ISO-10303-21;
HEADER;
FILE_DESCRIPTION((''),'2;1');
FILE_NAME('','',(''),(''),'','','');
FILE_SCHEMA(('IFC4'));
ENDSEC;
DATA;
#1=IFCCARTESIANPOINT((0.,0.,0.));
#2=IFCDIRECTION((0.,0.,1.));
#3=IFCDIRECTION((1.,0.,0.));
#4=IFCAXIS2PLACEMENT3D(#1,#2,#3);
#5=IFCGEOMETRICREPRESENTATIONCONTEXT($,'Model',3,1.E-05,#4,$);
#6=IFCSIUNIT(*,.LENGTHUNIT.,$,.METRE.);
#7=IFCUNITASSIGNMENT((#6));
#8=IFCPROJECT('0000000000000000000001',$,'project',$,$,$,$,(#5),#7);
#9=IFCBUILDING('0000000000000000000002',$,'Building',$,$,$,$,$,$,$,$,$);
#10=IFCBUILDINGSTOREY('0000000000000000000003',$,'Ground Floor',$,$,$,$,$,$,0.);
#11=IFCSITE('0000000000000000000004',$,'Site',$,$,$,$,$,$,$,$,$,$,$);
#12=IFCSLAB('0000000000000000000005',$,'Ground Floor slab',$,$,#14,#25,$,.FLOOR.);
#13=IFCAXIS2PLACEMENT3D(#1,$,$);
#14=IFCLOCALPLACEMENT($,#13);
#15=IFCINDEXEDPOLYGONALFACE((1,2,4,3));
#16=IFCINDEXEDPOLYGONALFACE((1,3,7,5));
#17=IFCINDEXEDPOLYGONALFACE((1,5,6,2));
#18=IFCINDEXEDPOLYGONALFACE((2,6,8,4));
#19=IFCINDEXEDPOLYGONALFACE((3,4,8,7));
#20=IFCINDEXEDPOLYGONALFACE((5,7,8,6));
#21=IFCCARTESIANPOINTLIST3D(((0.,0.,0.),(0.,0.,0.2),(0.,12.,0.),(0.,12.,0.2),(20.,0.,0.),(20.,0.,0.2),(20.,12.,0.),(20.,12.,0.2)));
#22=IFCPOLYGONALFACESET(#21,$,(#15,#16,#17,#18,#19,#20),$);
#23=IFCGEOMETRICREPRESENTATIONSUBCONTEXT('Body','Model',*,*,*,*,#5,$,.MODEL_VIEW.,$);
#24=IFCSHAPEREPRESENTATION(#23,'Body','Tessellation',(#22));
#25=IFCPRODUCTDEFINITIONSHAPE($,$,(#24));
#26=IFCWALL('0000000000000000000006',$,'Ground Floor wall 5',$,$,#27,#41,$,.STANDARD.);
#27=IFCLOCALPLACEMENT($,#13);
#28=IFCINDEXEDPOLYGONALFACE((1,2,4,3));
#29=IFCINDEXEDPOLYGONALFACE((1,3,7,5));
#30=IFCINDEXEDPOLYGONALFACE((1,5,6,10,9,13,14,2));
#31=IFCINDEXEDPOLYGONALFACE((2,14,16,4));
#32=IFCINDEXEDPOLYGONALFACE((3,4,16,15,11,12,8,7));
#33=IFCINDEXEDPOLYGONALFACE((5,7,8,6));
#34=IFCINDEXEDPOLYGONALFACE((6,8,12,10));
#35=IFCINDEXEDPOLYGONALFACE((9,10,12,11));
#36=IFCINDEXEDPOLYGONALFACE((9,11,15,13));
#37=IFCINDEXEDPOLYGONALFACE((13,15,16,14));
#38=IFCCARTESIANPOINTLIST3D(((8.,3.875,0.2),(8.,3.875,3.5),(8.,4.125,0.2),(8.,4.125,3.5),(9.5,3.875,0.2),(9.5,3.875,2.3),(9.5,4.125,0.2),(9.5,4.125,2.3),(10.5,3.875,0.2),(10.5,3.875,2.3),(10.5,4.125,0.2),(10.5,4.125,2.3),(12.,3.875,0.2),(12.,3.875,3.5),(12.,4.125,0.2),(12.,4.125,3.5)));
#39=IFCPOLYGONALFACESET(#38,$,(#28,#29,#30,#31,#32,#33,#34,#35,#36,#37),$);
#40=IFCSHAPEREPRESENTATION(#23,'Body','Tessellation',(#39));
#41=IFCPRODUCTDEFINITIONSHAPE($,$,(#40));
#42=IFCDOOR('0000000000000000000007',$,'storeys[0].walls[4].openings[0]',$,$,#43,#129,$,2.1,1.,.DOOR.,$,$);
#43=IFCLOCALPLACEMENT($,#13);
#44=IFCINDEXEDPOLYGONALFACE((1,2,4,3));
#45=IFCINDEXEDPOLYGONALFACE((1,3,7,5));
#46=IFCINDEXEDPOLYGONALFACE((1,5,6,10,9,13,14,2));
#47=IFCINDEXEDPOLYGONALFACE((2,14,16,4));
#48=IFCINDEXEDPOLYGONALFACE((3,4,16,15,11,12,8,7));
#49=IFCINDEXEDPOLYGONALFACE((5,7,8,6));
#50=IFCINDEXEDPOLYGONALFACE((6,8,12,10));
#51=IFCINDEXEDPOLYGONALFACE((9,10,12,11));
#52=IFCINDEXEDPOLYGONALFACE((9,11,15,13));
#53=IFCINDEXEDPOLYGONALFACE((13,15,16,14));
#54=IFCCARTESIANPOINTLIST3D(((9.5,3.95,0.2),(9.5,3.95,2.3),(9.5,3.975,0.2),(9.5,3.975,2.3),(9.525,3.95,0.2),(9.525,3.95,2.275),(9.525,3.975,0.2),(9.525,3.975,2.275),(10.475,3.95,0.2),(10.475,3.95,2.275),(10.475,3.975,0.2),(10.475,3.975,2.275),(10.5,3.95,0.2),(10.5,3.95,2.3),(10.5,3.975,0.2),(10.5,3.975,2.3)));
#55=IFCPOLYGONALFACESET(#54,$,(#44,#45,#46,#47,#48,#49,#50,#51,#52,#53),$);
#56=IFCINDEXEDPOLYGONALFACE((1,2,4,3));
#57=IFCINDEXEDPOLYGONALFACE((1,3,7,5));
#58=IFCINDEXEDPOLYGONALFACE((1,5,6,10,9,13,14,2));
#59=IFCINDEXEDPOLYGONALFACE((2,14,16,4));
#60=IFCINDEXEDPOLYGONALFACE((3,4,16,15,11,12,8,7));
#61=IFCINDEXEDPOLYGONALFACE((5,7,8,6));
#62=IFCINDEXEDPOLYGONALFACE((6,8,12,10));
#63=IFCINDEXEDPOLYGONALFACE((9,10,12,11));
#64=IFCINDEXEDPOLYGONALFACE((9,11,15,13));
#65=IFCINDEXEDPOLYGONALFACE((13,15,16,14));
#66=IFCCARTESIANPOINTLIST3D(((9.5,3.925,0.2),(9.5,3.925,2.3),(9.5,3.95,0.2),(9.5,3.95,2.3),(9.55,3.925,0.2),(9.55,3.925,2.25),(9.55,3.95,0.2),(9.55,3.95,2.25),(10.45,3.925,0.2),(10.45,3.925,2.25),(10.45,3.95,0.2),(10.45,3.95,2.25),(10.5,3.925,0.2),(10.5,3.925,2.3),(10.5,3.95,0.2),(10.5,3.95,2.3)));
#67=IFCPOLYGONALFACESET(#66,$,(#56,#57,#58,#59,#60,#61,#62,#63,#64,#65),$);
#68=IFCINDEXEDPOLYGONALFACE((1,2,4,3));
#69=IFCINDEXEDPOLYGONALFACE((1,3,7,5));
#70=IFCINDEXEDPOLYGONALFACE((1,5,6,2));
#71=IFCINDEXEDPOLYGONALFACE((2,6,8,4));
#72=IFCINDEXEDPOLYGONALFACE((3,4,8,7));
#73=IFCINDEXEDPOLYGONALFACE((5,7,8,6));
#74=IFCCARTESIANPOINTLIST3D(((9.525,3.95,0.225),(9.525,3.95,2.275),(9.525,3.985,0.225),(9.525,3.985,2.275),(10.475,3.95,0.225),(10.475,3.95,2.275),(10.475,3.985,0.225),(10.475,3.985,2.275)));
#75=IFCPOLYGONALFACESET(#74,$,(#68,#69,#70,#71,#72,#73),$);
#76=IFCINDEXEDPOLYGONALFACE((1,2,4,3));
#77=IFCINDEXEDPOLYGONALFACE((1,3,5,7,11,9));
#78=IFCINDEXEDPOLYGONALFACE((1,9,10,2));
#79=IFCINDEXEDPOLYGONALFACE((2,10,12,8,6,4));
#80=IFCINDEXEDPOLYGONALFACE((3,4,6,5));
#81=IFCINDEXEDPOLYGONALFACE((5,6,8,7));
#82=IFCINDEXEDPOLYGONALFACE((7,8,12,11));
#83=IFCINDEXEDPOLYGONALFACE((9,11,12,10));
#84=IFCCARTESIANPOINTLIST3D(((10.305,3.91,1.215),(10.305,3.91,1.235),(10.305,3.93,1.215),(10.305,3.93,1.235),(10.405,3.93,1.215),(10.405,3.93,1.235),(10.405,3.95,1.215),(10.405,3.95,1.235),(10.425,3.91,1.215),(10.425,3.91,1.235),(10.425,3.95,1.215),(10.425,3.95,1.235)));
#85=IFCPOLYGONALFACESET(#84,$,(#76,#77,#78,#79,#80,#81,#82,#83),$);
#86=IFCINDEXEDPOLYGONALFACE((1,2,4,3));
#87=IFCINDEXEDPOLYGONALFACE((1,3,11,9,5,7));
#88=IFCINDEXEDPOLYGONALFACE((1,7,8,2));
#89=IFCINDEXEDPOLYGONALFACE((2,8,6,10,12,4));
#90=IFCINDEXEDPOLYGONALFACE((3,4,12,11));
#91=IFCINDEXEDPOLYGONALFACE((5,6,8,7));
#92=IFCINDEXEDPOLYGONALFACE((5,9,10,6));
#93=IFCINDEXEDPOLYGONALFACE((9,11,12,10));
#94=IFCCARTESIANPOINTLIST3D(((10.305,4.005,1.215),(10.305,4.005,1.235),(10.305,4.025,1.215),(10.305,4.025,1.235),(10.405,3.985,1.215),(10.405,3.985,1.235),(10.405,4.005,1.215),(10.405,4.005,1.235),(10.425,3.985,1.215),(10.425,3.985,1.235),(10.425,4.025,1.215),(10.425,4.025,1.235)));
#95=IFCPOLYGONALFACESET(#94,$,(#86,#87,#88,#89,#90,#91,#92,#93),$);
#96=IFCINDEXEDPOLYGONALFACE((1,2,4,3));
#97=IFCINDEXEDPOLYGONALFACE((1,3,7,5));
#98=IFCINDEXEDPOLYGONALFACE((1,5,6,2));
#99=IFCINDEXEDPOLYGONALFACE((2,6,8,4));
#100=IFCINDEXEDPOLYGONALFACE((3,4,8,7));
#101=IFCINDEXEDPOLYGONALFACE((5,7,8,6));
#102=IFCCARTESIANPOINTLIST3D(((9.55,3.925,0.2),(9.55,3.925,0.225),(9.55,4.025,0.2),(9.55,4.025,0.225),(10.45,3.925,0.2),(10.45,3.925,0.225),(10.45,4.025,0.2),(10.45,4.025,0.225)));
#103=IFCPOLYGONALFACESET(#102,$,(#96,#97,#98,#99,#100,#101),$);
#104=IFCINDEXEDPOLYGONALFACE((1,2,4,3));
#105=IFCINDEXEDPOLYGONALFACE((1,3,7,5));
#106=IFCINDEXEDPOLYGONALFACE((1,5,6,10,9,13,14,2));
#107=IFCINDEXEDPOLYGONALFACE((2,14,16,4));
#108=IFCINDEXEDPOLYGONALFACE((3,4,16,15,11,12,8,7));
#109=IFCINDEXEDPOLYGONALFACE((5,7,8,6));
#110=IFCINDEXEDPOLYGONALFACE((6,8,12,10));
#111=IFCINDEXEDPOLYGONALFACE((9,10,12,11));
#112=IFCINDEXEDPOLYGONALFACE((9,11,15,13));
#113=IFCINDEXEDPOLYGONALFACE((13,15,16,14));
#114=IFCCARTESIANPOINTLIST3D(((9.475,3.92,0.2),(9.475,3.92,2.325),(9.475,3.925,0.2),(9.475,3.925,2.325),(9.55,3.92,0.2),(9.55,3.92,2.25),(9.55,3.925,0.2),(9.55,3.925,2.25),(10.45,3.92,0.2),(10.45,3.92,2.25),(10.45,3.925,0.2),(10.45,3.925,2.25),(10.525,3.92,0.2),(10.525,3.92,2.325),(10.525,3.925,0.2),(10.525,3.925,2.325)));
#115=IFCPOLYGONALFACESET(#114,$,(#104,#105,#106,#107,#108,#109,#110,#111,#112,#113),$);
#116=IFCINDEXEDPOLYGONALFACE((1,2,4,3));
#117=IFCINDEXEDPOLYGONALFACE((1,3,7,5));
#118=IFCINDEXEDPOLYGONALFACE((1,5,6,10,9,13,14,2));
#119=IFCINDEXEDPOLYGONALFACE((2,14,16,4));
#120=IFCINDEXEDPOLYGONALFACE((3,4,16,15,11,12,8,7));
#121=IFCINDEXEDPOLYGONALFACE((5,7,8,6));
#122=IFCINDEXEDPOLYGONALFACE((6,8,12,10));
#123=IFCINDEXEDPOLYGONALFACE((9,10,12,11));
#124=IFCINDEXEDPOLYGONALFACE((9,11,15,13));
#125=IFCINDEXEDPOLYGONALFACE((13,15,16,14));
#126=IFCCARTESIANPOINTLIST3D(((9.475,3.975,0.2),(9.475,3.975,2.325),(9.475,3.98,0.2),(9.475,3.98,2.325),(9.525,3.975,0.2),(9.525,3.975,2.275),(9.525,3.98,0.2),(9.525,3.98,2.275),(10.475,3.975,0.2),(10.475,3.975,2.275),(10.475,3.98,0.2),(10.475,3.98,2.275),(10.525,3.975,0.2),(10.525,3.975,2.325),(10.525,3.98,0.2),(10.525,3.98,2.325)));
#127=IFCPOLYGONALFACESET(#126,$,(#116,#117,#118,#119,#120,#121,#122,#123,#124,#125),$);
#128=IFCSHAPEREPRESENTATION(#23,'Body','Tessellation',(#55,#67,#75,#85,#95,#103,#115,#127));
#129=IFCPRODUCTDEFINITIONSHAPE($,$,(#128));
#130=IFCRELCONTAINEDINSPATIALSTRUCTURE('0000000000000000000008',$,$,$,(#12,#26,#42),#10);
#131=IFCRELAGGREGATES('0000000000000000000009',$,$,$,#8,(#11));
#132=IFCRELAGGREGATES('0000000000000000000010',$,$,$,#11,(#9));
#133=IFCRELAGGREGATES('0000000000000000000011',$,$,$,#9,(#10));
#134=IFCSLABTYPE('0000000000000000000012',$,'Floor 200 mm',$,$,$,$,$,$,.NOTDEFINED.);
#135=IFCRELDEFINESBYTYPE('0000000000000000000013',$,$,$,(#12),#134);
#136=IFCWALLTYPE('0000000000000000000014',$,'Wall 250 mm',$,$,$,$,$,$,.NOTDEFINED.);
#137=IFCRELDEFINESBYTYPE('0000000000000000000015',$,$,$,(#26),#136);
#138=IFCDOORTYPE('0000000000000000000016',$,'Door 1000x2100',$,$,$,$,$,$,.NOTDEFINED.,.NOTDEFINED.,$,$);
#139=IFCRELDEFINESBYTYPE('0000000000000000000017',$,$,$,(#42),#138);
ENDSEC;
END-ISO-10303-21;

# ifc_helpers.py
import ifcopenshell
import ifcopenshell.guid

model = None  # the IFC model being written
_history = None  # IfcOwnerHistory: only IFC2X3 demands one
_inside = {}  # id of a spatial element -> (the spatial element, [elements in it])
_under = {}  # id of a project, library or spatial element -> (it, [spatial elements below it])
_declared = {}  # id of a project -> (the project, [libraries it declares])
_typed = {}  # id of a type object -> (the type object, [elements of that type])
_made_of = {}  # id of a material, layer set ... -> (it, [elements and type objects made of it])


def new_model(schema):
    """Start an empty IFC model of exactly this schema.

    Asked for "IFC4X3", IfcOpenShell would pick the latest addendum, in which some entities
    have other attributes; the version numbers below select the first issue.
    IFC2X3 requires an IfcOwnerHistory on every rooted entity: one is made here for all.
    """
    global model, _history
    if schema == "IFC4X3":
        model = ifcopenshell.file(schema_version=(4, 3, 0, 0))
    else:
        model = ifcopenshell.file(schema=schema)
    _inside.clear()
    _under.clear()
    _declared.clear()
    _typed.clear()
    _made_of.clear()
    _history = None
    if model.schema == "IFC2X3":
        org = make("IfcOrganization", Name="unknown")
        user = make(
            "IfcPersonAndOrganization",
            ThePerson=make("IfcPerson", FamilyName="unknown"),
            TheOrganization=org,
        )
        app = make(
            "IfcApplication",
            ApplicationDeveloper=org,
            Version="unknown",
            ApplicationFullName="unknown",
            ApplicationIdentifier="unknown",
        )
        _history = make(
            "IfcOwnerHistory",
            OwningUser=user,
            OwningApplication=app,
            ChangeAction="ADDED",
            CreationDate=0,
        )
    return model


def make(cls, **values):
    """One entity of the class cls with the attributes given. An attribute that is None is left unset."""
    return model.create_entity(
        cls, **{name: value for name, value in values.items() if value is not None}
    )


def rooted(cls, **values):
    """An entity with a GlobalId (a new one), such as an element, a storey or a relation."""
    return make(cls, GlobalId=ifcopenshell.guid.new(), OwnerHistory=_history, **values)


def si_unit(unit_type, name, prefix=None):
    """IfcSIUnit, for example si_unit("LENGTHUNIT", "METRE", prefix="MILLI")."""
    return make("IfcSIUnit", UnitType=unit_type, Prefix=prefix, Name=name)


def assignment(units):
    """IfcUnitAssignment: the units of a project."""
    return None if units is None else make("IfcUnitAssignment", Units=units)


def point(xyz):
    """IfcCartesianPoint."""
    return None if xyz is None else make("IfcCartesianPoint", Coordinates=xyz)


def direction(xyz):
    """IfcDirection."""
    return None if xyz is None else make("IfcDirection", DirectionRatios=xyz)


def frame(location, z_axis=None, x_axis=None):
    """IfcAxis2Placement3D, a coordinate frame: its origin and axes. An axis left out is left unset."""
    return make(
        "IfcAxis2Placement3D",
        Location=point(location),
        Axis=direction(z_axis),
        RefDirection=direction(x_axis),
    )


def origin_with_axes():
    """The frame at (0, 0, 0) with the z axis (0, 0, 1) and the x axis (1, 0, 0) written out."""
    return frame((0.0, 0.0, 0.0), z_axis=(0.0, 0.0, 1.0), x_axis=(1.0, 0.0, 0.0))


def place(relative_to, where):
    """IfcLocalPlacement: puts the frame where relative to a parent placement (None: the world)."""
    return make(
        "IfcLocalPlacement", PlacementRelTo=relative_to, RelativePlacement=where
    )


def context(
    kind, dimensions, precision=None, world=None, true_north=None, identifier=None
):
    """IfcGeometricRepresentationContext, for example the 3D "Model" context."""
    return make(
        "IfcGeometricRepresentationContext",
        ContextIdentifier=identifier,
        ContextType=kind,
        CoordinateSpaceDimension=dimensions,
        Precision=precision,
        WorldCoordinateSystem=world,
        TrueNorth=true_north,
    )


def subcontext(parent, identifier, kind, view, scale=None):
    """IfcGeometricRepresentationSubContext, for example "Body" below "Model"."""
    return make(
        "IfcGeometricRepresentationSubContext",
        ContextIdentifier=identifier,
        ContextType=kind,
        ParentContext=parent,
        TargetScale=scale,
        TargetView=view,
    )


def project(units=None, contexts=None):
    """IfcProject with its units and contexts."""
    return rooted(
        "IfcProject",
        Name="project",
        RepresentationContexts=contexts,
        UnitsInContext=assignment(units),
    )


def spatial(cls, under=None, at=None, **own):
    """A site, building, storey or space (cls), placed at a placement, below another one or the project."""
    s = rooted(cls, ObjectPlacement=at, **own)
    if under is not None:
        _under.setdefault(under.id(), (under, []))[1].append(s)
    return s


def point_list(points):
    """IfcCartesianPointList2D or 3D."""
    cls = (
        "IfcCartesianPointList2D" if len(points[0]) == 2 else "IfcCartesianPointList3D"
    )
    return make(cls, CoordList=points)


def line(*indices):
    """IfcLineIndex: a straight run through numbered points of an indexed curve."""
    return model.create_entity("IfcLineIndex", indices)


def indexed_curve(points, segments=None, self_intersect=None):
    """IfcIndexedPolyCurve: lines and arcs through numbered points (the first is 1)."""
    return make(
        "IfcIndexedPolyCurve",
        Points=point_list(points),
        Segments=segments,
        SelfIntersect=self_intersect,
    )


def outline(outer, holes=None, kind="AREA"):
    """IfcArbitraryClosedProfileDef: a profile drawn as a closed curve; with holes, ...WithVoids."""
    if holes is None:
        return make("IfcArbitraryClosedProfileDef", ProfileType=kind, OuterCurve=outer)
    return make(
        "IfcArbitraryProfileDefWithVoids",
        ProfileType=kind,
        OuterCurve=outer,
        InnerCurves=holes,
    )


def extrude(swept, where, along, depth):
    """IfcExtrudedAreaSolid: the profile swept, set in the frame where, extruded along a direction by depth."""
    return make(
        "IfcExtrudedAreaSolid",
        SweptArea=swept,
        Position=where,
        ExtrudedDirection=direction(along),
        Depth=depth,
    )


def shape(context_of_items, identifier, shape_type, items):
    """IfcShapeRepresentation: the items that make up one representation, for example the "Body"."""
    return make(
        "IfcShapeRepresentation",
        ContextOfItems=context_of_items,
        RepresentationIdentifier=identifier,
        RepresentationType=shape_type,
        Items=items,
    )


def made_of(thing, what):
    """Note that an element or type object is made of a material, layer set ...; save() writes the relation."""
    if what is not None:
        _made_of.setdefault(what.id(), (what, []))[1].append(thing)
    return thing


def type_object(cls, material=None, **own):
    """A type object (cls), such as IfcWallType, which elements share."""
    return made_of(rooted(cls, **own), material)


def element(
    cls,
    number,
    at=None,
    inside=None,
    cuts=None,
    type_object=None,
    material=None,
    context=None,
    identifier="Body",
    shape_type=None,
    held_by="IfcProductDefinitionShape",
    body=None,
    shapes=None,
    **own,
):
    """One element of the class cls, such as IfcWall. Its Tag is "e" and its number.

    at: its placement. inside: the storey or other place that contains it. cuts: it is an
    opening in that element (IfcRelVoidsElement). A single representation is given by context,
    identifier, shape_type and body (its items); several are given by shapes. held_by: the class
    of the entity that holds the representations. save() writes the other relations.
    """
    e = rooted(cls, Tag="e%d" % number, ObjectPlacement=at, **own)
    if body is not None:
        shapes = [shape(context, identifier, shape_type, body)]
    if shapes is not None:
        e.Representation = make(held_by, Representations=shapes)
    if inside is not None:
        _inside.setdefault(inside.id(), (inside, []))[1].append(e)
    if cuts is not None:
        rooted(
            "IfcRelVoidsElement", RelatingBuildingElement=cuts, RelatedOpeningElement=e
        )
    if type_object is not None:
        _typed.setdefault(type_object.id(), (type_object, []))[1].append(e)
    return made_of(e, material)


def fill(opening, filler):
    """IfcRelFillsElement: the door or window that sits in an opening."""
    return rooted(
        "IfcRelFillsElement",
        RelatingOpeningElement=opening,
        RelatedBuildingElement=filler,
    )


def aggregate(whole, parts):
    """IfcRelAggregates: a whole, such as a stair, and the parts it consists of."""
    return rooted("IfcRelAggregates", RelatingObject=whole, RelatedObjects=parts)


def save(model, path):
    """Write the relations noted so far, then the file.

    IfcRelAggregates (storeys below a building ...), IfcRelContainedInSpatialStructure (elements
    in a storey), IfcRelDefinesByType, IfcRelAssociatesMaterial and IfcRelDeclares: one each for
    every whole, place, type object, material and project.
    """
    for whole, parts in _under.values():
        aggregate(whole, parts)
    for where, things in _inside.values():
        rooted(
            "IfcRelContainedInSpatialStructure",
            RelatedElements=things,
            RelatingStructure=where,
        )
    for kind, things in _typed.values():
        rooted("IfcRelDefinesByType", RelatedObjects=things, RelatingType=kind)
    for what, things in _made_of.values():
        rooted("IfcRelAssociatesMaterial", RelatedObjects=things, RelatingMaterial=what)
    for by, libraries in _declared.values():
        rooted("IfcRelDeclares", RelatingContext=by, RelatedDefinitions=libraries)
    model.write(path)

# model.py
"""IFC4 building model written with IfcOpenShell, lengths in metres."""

from ifc_helpers import new_model, si_unit, frame, origin_with_axes, place, context, subcontext, project, spatial, line, indexed_curve, outline, extrude, type_object, element, fill, save


model = new_model("IFC4")

# Units and contexts
model_context = context("Model", 3, precision=1e-05, world=origin_with_axes())
body_context = subcontext(model_context, "Body", "Model", "MODEL_VIEW")
ifc_project = project(units=[si_unit("LENGTHUNIT", "METRE")], contexts=[model_context])

# Site, building, storey
site = spatial("IfcSite", under=ifc_project, Name="Site")
building = spatial("IfcBuilding", under=site, Name="Building")
storey = spatial("IfcBuildingStorey", under=building, Name="Ground Floor", Elevation=0.0)

# Slab
slab_type = type_object("IfcSlabType", Name="Floor 200 mm", PredefinedType="NOTDEFINED")
slab_placement = place(None, origin_with_axes())
element("IfcSlab", 1, at=slab_placement, inside=storey, type_object=slab_type, Name="Ground Floor slab", PredefinedType="FLOOR", context=body_context, shape_type="SweptSolid", body=[
    extrude(outline(indexed_curve([(0.0, 0.0), (20.0, 0.0), (20.0, 12.0), (0.0, 12.0)])), None, (0.0, 0.0, 1.0), 0.2),
])

# Wall, opening, door
wall_type_1 = type_object("IfcWallType", Name="Wall 250 mm", PredefinedType="NOTDEFINED")
wall_1_placement = place(None, frame((8.0, 4.0, 0.2), z_axis=(0.0, 0.0, 1.0), x_axis=(1.0, 0.0, 0.0)))
wall_1 = element("IfcWall", 2, at=wall_1_placement, inside=storey, type_object=wall_type_1, Name="Ground Floor wall 5", PredefinedType="STANDARD", context=body_context, shape_type="SweptSolid", body=[
    extrude(outline(indexed_curve([(0.0, 0.0), (0.0, 0.25), (4.0, 0.25), (4.0, 0.0), (0.0, 0.0)], self_intersect=False)), frame((0.0, -0.125, 0.0), z_axis=(0.0, 0.0, 1.0), x_axis=(1.0, 0.0, 0.0)), (0.0, 0.0, 1.0), 3.3),
])
opening_1_placement = place(wall_1_placement, frame((1.5, -0.135, 0.0), z_axis=(0.0, 0.0, 1.0), x_axis=(1.0, 0.0, 0.0)))
opening_1 = element("IfcOpeningElement", 3, at=opening_1_placement, cuts=wall_1, context=body_context, shape_type="SweptSolid", body=[
    extrude(outline(indexed_curve([(0.0, 0.0), (0.0, 0.27), (1.0, 0.27), (1.0, 0.0), (0.0, 0.0)], self_intersect=False)), origin_with_axes(), (0.0, 0.0, 1.0), 2.1),
])
door_type_1 = type_object("IfcDoorType", Name="Door 1000x2100", OperationType="NOTDEFINED", PredefinedType="NOTDEFINED")
door_1_placement = place(None, frame((9.5, 3.925, 0.2), z_axis=(0.0, 0.0, 1.0), x_axis=(1.0, 0.0, 0.0)))
door_1 = element("IfcDoor", 4, at=door_1_placement, inside=storey, type_object=door_type_1, Name="storeys[0].walls[4].openings[0]", OverallHeight=2.1, OverallWidth=1.0, PredefinedType="DOOR", context=body_context, shape_type="SweptSolid", body=[
    extrude(outline(indexed_curve([(0.0, 0.0), (0.0, 2.1), (1.0, 2.1), (1.0, 0.0), (0.975, 0.0), (0.975, 2.075), (0.025, 2.075), (0.025, 0.0)], segments=[line(1, 2, 3, 4, 5, 6, 7, 8, 1)])), frame((0.0, 0.025, 0.0), z_axis=(0.0, -1.0, 0.0), x_axis=(1.0, 0.0, 0.0)), (0.0, 0.0, -1.0), 0.025),
    extrude(outline(indexed_curve([(0.0, 0.0), (0.0, 2.1), (1.0, 2.1), (1.0, 0.0), (0.95, 0.0), (0.95, 2.05), (0.05, 2.05), (0.05, 0.0)], segments=[line(1, 2, 3, 4, 5, 6, 7, 8, 1)])), frame((0.0, 0.0, 0.0), z_axis=(0.0, -1.0, 0.0), x_axis=(1.0, 0.0, 0.0)), (0.0, 0.0, -1.0), 0.025),
    extrude(outline(indexed_curve([(0.0, 0.0), (0.95, 0.0), (0.95, 0.035), (0.0, 0.035)], segments=[line(1, 2, 3, 4, 1)])), frame((0.025, 0.025, 0.025), z_axis=(0.0, 0.0, 1.0), x_axis=(1.0, 0.0, 0.0)), (0.0, 0.0, 1.0), 2.05),
    extrude(outline(indexed_curve([(0.0, 0.0), (0.0, -0.04), (-0.12, -0.04), (-0.12, -0.02), (-0.02, -0.02), (-0.02, 0.0)], segments=[line(1, 2, 3, 4, 5, 6, 1)])), frame((0.925, 0.025, 1.015), z_axis=(0.0, 0.0, 1.0), x_axis=(1.0, 0.0, 0.0)), (0.0, 0.0, 1.0), 0.02),
    extrude(outline(indexed_curve([(0.0, 0.0), (0.0, 0.04), (-0.12, 0.04), (-0.12, 0.02), (-0.02, 0.02), (-0.02, 0.0)], segments=[line(1, 2, 3, 4, 5, 6, 1)])), frame((0.925, 0.06, 1.015), z_axis=(0.0, 0.0, 1.0), x_axis=(1.0, 0.0, 0.0)), (0.0, 0.0, 1.0), 0.02),
    extrude(outline(indexed_curve([(0.0, 0.0), (0.9, 0.0), (0.9, 0.1), (0.0, 0.1)], segments=[line(1, 2, 3, 4, 1)])), frame((0.05, 0.0, 0.0), z_axis=(0.0, 0.0, 1.0), x_axis=(1.0, 0.0, 0.0)), (0.0, 0.0, 1.0), 0.025),
    extrude(outline(indexed_curve([(0.0, 0.0), (0.0, 2.125), (1.05, 2.125), (1.05, 0.0), (0.975, 0.0), (0.975, 2.05), (0.075, 2.05), (0.075, 0.0)], segments=[line(1, 2, 3, 4, 5, 6, 7, 8, 1)])), frame((-0.025, -0.005, 0.0), z_axis=(0.0, -1.0, 0.0), x_axis=(1.0, 0.0, 0.0)), (0.0, 0.0, -1.0), 0.005),
    extrude(outline(indexed_curve([(0.0, 0.0), (0.0, 2.125), (1.05, 2.125), (1.05, 0.0), (1.0, 0.0), (1.0, 2.075), (0.05, 2.075), (0.05, 0.0)], segments=[line(1, 2, 3, 4, 5, 6, 7, 8, 1)])), frame((-0.025, 0.05, 0.0), z_axis=(0.0, -1.0, 0.0), x_axis=(1.0, 0.0, 0.0)), (0.0, 0.0, -1.0), 0.005),
])
fill(opening_1, door_1)

save(model, "model.ifc")
